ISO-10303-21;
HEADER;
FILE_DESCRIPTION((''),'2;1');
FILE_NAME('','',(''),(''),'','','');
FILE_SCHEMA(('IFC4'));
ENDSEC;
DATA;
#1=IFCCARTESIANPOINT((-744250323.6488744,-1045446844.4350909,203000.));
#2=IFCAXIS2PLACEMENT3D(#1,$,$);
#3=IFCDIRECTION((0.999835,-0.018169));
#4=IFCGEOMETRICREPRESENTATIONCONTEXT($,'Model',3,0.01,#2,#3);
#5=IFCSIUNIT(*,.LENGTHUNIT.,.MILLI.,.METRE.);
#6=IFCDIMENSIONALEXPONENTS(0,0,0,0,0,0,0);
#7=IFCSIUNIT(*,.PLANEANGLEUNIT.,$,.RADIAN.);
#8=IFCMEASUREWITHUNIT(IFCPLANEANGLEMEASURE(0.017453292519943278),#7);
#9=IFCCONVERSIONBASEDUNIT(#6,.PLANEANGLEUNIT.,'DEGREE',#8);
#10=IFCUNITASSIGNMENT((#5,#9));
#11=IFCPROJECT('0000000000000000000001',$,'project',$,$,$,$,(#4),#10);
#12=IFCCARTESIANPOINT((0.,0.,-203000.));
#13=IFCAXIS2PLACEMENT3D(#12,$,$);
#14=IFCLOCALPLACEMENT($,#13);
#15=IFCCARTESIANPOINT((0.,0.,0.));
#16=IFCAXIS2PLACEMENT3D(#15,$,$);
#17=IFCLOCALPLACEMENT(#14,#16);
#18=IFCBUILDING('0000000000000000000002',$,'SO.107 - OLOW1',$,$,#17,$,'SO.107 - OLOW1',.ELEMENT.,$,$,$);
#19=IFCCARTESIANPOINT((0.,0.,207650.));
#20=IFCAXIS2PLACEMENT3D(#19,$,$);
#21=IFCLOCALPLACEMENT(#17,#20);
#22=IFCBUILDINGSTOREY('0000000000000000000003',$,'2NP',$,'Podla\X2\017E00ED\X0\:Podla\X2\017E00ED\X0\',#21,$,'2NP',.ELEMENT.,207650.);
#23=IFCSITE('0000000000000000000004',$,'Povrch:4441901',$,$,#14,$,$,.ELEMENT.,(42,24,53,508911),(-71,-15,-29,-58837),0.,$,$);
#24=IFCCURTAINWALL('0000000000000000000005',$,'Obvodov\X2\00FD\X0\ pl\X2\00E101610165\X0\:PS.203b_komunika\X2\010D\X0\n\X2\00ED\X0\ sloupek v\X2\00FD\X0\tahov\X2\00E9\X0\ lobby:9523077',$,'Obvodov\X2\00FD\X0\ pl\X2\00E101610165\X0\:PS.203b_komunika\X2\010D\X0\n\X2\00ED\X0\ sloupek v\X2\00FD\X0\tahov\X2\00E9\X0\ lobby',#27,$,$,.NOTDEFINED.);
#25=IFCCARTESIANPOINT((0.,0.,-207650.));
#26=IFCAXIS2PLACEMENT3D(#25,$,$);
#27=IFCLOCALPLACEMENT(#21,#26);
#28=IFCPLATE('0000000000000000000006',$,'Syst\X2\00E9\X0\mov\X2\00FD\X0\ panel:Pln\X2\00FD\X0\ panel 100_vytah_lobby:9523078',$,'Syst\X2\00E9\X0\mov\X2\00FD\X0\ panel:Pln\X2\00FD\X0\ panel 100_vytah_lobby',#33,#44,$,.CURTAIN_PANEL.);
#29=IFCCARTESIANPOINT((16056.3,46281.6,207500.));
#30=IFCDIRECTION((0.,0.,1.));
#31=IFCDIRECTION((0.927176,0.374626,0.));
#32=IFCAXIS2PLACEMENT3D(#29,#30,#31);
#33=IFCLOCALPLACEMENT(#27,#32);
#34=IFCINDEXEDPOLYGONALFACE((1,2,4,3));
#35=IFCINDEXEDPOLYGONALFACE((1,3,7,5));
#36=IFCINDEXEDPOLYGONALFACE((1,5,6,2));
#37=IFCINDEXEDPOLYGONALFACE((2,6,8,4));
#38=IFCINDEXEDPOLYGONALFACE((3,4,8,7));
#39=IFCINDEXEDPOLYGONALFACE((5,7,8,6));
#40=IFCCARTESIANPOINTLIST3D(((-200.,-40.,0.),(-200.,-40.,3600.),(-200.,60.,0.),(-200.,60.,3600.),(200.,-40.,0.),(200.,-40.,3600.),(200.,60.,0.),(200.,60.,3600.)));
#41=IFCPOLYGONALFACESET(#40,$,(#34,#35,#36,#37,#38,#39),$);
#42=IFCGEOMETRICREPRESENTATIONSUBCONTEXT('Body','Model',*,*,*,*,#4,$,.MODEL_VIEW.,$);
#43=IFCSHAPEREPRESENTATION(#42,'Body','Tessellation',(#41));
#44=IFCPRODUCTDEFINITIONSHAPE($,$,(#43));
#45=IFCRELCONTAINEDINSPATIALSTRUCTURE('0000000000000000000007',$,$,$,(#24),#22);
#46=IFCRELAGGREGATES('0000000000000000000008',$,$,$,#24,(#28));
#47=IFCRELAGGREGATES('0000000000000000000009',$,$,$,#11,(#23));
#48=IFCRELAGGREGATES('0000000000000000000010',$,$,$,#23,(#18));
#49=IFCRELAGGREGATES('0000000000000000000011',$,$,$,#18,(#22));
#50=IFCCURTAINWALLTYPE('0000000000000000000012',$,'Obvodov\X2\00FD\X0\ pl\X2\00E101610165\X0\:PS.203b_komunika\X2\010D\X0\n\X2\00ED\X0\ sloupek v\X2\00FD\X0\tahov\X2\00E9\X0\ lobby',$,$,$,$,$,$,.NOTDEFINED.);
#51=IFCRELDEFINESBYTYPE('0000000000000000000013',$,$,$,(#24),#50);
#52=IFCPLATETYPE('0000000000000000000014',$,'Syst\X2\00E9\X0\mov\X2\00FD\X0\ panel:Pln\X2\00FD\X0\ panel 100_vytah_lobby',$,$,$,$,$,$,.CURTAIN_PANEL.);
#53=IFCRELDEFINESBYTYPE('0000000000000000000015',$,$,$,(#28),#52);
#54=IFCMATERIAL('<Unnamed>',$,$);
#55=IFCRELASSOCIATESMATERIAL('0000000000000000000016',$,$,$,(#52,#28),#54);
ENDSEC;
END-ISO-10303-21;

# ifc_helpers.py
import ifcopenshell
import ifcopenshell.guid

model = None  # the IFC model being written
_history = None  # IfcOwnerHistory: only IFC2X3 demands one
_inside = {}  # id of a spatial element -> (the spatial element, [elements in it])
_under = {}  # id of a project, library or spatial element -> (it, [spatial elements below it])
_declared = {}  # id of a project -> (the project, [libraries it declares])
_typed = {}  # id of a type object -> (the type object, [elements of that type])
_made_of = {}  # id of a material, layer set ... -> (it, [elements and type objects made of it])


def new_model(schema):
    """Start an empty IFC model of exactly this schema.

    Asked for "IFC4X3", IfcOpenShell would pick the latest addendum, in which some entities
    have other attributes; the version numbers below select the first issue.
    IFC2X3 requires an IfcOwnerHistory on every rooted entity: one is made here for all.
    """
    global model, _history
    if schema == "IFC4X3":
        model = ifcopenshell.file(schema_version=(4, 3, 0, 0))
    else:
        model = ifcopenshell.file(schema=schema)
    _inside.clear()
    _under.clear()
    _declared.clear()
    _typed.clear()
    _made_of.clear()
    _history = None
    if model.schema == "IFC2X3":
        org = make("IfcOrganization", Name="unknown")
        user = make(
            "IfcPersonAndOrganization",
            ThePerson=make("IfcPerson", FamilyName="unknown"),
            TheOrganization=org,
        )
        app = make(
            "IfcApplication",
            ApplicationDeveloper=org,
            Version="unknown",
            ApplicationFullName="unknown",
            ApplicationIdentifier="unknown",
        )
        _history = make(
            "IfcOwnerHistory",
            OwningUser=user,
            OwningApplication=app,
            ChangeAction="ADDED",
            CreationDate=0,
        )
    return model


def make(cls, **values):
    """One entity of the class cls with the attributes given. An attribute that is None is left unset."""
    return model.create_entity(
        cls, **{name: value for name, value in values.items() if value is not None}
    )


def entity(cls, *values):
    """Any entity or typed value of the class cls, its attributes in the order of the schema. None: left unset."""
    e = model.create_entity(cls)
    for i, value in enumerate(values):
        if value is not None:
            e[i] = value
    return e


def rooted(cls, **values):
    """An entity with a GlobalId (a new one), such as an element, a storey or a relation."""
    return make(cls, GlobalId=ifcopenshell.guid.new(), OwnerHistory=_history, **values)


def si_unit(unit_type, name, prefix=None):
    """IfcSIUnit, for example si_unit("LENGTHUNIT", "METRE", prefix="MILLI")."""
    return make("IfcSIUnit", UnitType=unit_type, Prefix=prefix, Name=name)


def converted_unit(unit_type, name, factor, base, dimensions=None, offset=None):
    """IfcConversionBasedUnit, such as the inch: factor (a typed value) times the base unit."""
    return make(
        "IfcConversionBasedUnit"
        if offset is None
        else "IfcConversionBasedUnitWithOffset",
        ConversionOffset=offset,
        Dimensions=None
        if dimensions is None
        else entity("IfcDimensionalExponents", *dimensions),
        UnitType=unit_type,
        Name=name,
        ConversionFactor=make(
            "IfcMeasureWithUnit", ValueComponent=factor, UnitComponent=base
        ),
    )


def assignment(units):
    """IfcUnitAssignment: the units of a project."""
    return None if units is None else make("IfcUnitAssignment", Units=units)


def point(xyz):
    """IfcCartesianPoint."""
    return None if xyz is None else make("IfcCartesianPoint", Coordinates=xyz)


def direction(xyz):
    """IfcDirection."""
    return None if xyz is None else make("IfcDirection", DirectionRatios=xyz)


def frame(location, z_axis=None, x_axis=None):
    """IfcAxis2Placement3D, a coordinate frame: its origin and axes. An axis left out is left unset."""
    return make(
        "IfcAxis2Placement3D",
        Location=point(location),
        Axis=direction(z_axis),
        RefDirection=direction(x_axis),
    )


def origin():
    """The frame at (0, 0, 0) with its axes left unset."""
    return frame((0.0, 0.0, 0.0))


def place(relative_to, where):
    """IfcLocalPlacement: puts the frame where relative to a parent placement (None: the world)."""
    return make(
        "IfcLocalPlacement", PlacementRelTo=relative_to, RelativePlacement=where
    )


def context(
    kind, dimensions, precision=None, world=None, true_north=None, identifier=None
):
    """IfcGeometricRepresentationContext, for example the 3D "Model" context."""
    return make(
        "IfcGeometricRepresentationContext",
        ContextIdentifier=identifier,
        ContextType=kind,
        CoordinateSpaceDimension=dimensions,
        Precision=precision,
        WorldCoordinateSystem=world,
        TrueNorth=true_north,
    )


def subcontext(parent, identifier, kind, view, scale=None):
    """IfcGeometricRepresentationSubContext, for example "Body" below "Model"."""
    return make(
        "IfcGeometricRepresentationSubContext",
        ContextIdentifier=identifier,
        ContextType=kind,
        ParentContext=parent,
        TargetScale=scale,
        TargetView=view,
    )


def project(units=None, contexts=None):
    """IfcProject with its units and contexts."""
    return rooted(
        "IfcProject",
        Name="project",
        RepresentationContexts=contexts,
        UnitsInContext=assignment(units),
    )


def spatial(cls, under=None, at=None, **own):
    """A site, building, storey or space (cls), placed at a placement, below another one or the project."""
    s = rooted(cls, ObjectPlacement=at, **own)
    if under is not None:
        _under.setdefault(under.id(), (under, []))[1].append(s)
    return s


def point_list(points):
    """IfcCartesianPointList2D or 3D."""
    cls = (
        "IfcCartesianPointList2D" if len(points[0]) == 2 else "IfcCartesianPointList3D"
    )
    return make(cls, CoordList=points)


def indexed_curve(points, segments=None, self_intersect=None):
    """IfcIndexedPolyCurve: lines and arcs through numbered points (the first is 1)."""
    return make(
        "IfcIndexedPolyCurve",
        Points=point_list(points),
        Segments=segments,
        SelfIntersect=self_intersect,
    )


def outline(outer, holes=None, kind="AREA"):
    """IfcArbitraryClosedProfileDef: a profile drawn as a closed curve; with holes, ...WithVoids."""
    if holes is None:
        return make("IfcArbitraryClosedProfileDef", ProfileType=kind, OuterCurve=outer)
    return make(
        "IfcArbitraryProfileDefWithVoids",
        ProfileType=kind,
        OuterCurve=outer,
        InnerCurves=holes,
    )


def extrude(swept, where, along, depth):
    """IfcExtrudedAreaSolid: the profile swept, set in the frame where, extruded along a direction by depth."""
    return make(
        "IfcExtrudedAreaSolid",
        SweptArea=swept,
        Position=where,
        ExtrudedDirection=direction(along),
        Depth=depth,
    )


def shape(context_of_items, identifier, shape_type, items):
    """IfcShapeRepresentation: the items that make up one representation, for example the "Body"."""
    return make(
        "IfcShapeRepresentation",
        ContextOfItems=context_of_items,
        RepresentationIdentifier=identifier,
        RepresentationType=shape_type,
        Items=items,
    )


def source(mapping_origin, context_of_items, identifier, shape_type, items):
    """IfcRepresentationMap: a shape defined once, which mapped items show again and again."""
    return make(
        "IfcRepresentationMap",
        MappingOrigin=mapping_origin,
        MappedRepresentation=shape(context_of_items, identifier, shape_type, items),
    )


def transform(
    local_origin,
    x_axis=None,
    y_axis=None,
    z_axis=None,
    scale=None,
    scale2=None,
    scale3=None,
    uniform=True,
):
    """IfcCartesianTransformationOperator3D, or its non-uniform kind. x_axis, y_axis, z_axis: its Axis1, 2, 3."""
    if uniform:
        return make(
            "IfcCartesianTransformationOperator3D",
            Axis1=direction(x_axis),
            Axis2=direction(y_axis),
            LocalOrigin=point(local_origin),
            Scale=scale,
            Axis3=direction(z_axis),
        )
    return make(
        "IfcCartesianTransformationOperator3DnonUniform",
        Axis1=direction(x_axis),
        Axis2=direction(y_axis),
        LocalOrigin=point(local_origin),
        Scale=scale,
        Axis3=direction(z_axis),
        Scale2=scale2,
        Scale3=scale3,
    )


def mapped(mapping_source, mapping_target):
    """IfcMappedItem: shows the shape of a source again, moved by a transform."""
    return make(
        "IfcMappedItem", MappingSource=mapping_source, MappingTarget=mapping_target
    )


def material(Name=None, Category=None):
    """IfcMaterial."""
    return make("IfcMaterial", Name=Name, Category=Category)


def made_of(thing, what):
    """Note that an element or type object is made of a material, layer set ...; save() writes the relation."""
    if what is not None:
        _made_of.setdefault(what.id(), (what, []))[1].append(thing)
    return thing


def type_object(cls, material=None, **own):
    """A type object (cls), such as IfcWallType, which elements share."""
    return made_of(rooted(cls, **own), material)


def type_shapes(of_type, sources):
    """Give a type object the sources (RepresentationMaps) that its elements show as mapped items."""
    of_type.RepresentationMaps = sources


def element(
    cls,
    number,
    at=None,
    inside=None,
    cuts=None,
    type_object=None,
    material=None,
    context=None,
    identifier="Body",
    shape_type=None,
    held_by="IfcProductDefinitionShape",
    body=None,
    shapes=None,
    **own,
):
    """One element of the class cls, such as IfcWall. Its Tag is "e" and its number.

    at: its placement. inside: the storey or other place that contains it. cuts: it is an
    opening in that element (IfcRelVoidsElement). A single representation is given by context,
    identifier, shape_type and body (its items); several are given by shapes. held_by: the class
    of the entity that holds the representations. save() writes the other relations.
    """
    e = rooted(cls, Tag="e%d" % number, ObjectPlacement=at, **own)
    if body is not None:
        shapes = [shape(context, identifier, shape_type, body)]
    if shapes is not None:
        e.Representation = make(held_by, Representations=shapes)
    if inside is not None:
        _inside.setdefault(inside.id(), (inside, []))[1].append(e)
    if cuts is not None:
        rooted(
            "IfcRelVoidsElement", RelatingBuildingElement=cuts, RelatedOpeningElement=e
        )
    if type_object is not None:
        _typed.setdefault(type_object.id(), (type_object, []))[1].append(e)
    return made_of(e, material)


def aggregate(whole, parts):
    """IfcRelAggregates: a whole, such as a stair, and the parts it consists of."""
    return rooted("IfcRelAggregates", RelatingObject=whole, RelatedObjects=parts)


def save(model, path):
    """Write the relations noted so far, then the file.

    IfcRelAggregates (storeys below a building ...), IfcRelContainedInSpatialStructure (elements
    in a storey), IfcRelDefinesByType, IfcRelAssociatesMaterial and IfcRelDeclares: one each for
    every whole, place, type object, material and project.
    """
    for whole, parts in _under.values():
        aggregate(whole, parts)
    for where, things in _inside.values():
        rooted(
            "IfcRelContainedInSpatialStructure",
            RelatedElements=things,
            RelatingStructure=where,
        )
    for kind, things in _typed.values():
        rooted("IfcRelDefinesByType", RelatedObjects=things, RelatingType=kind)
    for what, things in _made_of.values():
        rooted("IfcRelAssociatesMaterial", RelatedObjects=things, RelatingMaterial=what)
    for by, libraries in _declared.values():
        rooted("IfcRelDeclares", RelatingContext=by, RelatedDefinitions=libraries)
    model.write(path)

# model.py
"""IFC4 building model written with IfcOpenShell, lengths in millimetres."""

from ifc_helpers import new_model, entity, si_unit, converted_unit, direction, frame, origin, place, context, subcontext, project, spatial, indexed_curve, outline, extrude, source, transform, mapped, material, type_object, type_shapes, element, aggregate, save


model = new_model("IFC4")

# Units and contexts
model_context = context("Model", 3, precision=0.01, world=frame((-744250323.6488744, -1045446844.4350909, 203000.0)), true_north=direction((0.999835, -0.018169)))
body_context = subcontext(model_context, "Body", "Model", "MODEL_VIEW")
ifc_project = project(units=[si_unit("LENGTHUNIT", "METRE", prefix="MILLI"), converted_unit("PLANEANGLEUNIT", "DEGREE", entity("IfcPlaneAngleMeasure", 0.017453292519943278), si_unit("PLANEANGLEUNIT", "RADIAN"), dimensions=[0, 0, 0, 0, 0, 0, 0])], contexts=[model_context])

# Site, building, storey
site_placement = place(None, frame((0.0, 0.0, -203000.0)))
site = spatial("IfcSite", under=ifc_project, at=site_placement, Name="Povrch:4441901", CompositionType="ELEMENT", RefLatitude=(42, 24, 53, 508911), RefLongitude=(-71, -15, -29, -58837), RefElevation=0.0)
building_placement = place(site_placement, origin())
building = spatial("IfcBuilding", under=site, at=building_placement, Name="SO.107 - OLOW1", LongName="SO.107 - OLOW1", CompositionType="ELEMENT")
storey_placement = place(building_placement, frame((0.0, 0.0, 207650.0)))
storey = spatial("IfcBuildingStorey", under=building, at=storey_placement, Name="2NP", ObjectType="Podlaží:Podlaží", LongName="2NP", CompositionType="ELEMENT", Elevation=207650.0)

# Shared definitions
ifc_material_1 = material(Name="<Unnamed>")

# Curtain wall, plate
curtain_wall_type_1 = type_object("IfcCurtainWallType", Name="Obvodový plášť:PS.203b_komunikační sloupek výtahové lobby", PredefinedType="NOTDEFINED")
curtain_wall_1_placement = place(storey_placement, frame((0.0, 0.0, -207650.0)))
curtain_wall_1 = element("IfcCurtainWall", 1, at=curtain_wall_1_placement, inside=storey, type_object=curtain_wall_type_1, Name="Obvodový plášť:PS.203b_komunikační sloupek výtahové lobby:9523077", ObjectType="Obvodový plášť:PS.203b_komunikační sloupek výtahové lobby", PredefinedType="NOTDEFINED")
plate_type_1 = type_object("IfcPlateType", Name="Systémový panel:Plný panel 100_vytah_lobby", PredefinedType="CURTAIN_PANEL", material=ifc_material_1)
shared_shape_1 = source(origin(), body_context, "Body", "SweptSolid", [
    extrude(outline(indexed_curve([(-50.0, -200.0), (50.0, -200.0), (50.0, 200.0), (-50.0, 200.0), (-50.0, -200.0)], self_intersect=False)), frame((0.0, 10.0, 0.0), z_axis=(0.0, 0.0, 1.0), x_axis=(0.0, 1.0, 0.0)), (0.0, 0.0, 1.0), 3600.0),
])
type_shapes(plate_type_1, [shared_shape_1])
plate_1_placement = place(curtain_wall_1_placement, frame((16056.3, 46281.6, 207500.0), z_axis=(0.0, 0.0, 1.0), x_axis=(0.927176, 0.374626, 0.0)))
plate_1 = element("IfcPlate", 2, at=plate_1_placement, type_object=plate_type_1, material=ifc_material_1, Name="Systémový panel:Plný panel 100_vytah_lobby:9523078", ObjectType="Systémový panel:Plný panel 100_vytah_lobby", PredefinedType="CURTAIN_PANEL", context=body_context, shape_type="MappedRepresentation", body=[
    mapped(shared_shape_1, transform((0.0, 0.0, 0.0), scale=1.0)),
])
aggregate(curtain_wall_1, [plate_1])

save(model, "model.ifc")
